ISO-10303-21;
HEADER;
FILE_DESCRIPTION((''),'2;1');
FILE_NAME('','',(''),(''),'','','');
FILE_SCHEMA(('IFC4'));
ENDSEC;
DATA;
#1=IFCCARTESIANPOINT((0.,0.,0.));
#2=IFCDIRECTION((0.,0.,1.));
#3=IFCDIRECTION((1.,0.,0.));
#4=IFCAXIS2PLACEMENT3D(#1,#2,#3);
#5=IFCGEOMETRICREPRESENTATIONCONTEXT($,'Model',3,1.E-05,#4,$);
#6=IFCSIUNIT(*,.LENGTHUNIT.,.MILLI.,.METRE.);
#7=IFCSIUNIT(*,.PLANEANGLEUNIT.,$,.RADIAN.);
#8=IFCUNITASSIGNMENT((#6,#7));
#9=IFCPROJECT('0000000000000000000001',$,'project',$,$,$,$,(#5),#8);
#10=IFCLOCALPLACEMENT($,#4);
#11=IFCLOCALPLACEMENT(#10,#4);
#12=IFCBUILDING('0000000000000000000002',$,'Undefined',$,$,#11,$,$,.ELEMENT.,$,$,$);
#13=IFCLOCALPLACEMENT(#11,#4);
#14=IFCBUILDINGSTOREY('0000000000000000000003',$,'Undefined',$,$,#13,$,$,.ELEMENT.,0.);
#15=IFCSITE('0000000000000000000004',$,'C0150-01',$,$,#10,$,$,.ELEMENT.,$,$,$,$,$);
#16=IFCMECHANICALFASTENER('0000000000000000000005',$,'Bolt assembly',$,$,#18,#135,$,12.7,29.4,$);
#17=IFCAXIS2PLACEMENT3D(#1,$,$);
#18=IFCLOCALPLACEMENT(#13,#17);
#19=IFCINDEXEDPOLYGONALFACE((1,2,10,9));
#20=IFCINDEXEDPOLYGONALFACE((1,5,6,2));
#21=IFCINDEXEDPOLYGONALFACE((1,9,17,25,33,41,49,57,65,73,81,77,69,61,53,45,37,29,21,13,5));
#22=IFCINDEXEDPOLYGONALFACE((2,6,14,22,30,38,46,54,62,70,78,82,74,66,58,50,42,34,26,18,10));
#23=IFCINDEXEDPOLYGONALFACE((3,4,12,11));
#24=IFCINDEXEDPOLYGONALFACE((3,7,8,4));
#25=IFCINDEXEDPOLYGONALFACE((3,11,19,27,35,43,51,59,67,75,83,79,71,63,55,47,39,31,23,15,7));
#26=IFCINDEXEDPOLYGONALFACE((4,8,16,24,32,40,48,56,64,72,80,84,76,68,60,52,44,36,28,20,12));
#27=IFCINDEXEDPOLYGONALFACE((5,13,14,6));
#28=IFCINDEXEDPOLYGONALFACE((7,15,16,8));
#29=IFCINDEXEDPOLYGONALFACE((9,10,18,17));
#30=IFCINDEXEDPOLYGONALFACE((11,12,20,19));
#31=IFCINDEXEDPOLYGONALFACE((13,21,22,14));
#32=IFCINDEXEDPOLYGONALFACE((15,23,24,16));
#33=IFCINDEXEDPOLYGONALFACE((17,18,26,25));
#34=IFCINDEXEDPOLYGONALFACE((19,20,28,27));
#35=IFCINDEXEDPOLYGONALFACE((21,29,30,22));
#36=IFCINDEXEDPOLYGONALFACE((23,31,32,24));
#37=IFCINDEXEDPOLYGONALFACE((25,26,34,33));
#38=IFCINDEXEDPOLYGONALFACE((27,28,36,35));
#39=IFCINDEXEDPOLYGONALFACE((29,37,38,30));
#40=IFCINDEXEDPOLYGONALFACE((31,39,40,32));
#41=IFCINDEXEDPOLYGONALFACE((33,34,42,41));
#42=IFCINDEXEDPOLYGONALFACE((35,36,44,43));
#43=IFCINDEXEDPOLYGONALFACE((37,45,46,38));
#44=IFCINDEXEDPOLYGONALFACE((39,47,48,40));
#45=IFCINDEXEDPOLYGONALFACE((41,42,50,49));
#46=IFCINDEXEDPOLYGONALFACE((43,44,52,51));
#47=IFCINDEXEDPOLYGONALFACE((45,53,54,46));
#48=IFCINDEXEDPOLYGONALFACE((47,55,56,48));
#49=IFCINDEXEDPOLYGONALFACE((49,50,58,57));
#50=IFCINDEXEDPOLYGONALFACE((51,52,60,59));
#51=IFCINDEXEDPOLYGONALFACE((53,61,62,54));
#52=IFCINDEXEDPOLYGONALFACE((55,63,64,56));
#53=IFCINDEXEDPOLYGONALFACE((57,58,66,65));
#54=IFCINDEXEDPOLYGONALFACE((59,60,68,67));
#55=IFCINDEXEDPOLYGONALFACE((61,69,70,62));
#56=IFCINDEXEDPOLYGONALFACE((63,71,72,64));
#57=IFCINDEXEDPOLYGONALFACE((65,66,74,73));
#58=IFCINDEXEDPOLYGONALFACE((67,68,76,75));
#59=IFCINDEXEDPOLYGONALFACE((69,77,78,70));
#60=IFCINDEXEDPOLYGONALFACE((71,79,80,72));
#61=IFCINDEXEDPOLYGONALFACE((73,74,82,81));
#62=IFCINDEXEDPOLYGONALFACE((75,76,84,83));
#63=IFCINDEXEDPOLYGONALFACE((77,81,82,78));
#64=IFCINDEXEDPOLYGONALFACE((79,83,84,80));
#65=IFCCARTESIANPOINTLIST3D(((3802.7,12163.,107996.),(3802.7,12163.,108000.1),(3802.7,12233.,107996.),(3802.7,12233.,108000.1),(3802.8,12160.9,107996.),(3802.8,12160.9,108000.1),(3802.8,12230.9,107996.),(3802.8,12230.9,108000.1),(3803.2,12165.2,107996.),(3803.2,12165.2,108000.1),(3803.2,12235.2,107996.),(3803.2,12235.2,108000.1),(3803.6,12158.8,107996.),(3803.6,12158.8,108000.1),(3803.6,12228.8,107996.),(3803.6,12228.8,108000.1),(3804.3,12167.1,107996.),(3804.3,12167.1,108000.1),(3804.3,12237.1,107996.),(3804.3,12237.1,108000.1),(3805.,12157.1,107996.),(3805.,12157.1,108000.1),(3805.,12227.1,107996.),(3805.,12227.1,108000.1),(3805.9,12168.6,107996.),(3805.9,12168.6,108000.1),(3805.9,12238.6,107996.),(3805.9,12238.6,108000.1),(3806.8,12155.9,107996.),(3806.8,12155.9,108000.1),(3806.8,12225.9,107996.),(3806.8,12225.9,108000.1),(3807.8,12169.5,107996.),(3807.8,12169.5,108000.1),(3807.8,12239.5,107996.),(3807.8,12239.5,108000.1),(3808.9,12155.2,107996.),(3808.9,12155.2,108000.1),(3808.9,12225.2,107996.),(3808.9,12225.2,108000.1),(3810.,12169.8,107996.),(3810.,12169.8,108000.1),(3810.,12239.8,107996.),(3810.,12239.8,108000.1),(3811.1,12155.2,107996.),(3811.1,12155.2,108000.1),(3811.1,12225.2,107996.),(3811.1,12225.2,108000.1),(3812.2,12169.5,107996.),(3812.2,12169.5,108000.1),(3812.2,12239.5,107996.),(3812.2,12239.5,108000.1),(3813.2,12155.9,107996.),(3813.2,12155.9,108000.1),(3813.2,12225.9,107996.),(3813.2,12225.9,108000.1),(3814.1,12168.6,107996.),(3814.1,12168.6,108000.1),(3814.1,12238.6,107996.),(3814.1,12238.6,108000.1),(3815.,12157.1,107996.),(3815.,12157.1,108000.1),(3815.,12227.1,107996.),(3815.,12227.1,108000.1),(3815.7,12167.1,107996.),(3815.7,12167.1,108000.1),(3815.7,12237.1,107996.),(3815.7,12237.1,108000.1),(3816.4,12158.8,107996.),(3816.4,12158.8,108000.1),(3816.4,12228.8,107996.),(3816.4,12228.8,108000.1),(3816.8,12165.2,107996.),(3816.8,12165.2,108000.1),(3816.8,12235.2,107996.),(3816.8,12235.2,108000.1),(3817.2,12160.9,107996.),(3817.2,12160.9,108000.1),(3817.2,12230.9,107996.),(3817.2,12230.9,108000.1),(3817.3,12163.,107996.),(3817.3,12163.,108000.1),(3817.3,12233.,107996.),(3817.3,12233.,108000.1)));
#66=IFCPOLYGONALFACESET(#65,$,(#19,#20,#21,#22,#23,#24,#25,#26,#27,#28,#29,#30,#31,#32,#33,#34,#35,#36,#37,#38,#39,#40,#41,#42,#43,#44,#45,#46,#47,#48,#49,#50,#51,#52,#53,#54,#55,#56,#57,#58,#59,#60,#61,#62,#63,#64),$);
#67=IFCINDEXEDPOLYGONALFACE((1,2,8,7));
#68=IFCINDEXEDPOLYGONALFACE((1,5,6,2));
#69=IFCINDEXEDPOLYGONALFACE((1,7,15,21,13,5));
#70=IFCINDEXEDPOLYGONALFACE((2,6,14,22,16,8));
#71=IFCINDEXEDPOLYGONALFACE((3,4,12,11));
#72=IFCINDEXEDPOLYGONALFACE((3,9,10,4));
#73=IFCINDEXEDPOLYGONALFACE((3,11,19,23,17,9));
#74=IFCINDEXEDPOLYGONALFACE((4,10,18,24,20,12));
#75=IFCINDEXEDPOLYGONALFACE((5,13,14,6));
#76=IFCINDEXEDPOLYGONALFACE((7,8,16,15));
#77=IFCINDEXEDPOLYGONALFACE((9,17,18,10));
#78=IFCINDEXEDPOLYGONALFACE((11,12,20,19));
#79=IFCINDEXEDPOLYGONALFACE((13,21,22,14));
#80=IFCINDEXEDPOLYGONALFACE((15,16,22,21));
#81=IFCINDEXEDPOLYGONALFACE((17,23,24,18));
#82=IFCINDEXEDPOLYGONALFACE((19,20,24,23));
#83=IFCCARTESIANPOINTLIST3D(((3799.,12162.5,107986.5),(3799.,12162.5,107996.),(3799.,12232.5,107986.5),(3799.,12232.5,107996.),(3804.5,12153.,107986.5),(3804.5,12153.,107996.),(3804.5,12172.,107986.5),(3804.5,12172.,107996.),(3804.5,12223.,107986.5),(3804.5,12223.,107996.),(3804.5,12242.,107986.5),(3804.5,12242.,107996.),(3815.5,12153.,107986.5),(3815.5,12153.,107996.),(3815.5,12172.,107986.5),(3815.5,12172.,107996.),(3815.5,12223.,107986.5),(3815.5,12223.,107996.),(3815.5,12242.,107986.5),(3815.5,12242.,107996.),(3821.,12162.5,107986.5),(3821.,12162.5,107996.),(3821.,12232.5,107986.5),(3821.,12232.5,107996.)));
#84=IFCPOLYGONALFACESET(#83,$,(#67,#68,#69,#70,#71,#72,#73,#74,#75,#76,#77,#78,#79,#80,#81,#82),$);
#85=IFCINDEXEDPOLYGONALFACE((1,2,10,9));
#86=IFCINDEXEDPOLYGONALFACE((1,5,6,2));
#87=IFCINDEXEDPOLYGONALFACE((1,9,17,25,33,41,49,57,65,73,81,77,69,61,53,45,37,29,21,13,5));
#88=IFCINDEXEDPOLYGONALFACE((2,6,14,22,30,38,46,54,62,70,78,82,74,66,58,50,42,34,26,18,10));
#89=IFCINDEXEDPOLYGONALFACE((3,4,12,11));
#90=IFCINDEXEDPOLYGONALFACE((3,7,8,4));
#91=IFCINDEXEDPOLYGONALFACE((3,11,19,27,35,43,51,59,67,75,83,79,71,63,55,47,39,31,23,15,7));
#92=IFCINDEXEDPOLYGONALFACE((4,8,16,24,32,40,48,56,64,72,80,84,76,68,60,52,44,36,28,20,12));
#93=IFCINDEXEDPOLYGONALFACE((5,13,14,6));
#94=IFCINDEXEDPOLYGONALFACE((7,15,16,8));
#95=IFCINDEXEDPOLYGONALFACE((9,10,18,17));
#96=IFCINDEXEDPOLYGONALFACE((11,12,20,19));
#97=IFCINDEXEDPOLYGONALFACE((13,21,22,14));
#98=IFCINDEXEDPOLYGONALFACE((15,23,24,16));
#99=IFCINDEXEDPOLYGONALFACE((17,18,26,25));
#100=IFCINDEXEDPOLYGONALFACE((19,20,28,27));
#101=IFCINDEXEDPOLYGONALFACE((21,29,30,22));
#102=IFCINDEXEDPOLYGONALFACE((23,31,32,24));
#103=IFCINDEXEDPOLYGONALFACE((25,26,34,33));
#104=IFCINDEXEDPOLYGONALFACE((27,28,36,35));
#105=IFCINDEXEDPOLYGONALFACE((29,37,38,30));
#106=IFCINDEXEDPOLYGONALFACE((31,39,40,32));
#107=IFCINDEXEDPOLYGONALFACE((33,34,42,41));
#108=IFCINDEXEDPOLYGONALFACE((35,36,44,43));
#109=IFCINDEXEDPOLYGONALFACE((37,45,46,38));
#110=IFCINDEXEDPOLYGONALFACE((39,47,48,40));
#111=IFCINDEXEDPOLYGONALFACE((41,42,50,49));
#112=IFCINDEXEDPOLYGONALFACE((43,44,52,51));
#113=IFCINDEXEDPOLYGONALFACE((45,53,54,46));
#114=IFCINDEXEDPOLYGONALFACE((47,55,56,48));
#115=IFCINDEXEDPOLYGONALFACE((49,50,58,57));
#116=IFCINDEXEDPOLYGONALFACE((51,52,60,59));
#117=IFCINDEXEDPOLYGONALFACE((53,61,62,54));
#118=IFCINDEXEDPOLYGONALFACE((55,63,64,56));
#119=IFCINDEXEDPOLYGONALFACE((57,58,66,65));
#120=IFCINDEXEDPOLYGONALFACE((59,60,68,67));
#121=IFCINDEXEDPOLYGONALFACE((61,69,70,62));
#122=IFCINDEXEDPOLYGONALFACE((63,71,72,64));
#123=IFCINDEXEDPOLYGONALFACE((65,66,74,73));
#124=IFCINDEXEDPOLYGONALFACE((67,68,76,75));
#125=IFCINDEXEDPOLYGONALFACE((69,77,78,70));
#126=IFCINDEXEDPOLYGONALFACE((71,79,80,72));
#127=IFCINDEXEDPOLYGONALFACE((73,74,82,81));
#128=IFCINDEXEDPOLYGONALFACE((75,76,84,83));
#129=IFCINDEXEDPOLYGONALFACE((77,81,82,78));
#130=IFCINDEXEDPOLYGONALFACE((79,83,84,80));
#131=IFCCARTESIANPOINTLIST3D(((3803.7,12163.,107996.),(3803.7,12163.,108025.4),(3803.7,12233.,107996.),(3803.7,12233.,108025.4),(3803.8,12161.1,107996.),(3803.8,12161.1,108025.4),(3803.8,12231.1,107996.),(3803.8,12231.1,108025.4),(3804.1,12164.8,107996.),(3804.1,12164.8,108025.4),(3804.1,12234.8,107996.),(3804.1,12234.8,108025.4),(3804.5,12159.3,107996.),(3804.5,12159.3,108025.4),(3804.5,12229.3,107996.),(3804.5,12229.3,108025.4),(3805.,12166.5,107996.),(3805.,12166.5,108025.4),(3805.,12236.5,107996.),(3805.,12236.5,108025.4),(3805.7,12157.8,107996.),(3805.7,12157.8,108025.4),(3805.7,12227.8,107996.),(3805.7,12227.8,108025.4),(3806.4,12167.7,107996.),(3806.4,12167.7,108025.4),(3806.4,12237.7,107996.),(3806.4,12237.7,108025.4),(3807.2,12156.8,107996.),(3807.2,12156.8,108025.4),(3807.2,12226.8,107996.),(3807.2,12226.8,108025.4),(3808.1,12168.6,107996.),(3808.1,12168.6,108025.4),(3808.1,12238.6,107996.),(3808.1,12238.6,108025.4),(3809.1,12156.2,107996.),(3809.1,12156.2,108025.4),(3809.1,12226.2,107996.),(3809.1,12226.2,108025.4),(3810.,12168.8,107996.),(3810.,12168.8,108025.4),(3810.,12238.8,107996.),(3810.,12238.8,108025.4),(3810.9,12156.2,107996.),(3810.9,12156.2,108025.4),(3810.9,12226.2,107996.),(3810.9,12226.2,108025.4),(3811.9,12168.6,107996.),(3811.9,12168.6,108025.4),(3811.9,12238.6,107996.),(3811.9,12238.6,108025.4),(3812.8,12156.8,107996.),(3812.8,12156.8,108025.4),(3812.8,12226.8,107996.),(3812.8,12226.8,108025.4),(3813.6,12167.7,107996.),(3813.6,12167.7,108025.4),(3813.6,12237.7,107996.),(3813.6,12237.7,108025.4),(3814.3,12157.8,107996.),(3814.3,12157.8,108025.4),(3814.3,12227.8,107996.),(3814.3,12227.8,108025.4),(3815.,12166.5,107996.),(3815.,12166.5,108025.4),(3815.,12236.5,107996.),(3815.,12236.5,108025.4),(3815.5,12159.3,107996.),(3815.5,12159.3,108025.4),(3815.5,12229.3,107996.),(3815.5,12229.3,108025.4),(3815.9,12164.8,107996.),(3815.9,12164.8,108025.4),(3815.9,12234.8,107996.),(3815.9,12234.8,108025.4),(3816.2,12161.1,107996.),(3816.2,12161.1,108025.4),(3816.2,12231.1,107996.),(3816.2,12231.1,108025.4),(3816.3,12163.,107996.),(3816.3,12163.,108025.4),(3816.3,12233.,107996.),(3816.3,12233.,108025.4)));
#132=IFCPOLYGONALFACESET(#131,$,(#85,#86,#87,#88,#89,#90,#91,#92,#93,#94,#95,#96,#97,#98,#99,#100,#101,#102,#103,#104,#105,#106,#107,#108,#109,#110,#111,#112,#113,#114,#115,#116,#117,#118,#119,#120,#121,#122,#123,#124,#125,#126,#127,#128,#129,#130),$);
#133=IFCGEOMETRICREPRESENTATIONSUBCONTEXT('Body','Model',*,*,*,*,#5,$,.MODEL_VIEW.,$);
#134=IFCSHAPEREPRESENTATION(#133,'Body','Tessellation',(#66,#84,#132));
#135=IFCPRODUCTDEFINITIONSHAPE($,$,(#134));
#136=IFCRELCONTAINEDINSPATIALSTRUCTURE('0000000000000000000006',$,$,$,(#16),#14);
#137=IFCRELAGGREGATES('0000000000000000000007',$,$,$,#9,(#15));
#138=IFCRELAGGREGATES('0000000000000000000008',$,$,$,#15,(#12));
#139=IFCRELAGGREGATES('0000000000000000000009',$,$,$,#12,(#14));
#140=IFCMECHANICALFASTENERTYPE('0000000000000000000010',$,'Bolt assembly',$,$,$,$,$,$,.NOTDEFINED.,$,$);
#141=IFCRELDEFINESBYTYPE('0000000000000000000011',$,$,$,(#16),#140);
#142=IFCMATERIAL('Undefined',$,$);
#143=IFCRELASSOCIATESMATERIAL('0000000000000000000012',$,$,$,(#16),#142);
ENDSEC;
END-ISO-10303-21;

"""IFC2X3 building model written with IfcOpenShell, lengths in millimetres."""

from ifc_helpers import new_model, si_unit, frame, origin_with_axes, origin_2d_with_axis, place, context, subcontext, project, spatial, polyline, circle, outline, extrude, source, transform, mapped, material, type_object, element, save


model = new_model("IFC2X3")

# Units and contexts
model_context = context("Model", 3, precision=1e-05, world=origin_with_axes())
body_context = subcontext(model_context, "Body", "Model", "MODEL_VIEW")
ifc_project = project(units=[si_unit("LENGTHUNIT", "METRE", prefix="MILLI"), si_unit("PLANEANGLEUNIT", "RADIAN")], contexts=[model_context])

# Site, building, storey
site_placement = place(None, origin_with_axes())
site = spatial("IfcSite", under=ifc_project, at=site_placement, Name="C0150-01", CompositionType="ELEMENT")
building_placement = place(site_placement, origin_with_axes())
building = spatial("IfcBuilding", under=site, at=building_placement, Name="Undefined", CompositionType="ELEMENT")
storey_placement = place(building_placement, origin_with_axes())
storey = spatial("IfcBuildingStorey", under=building, at=storey_placement, Name="Undefined", CompositionType="ELEMENT", Elevation=0.0)

# Mechanical fastener
ifc_material_1 = material(Name="Undefined")
mechanical_fastener_type = type_object("IfcMechanicalFastenerType", Name="Bolt assembly")
shared_shape_1 = source(origin_with_axes(), body_context, "Body", "SweptSolid", [
    extrude(circle(Radius=7.3, at=origin_2d_with_axis()), frame((0.0, 0.0, 0.0), z_axis=(0.0, 1.0, 0.0), x_axis=(1.0, 0.0, 0.0)), (0.0, 0.0, 1.0), 4.1),
    extrude(outline(polyline([(9.5, -5.5), (9.5, 5.5), (0.0, 11.0), (-9.5, 5.5), (-9.5, -5.5), (0.0, -11.0), (9.5, -5.5)])), frame((0.0, -9.5, 0.0), z_axis=(0.0, 1.0, 0.0), x_axis=(1.0, 0.0, 0.0)), (0.0, 0.0, 1.0), 9.5),
    extrude(circle(Radius=6.3, at=origin_2d_with_axis()), frame((0.0, 0.0, 0.0), z_axis=(0.0, 1.0, 0.0), x_axis=(1.0, 0.0, 0.0)), (0.0, 0.0, 1.0), 29.4),
])
for number, where, z_axis, x_axis, name in (
    (1, (3810.0, 12162.5, 107996.0), (1.0, 0.0, 0.0), (0.0, 1.0, 0.0), "Bolt assembly"),
):
    element("IfcMechanicalFastener", number, at=place(storey_placement, frame(where, z_axis=z_axis, x_axis=x_axis)), inside=storey, type_object=mechanical_fastener_type, material=ifc_material_1, Name=name, NominalDiameter=12.7, NominalLength=29.4, context=body_context, shape_type="MappedRepresentation", body=[
        mapped(shared_shape_1, transform((0.0, 0.0, 0.0))),
        mapped(shared_shape_1, transform((70.0, 0.0, 0.0))),
    ])

save(model, "model.ifc")
